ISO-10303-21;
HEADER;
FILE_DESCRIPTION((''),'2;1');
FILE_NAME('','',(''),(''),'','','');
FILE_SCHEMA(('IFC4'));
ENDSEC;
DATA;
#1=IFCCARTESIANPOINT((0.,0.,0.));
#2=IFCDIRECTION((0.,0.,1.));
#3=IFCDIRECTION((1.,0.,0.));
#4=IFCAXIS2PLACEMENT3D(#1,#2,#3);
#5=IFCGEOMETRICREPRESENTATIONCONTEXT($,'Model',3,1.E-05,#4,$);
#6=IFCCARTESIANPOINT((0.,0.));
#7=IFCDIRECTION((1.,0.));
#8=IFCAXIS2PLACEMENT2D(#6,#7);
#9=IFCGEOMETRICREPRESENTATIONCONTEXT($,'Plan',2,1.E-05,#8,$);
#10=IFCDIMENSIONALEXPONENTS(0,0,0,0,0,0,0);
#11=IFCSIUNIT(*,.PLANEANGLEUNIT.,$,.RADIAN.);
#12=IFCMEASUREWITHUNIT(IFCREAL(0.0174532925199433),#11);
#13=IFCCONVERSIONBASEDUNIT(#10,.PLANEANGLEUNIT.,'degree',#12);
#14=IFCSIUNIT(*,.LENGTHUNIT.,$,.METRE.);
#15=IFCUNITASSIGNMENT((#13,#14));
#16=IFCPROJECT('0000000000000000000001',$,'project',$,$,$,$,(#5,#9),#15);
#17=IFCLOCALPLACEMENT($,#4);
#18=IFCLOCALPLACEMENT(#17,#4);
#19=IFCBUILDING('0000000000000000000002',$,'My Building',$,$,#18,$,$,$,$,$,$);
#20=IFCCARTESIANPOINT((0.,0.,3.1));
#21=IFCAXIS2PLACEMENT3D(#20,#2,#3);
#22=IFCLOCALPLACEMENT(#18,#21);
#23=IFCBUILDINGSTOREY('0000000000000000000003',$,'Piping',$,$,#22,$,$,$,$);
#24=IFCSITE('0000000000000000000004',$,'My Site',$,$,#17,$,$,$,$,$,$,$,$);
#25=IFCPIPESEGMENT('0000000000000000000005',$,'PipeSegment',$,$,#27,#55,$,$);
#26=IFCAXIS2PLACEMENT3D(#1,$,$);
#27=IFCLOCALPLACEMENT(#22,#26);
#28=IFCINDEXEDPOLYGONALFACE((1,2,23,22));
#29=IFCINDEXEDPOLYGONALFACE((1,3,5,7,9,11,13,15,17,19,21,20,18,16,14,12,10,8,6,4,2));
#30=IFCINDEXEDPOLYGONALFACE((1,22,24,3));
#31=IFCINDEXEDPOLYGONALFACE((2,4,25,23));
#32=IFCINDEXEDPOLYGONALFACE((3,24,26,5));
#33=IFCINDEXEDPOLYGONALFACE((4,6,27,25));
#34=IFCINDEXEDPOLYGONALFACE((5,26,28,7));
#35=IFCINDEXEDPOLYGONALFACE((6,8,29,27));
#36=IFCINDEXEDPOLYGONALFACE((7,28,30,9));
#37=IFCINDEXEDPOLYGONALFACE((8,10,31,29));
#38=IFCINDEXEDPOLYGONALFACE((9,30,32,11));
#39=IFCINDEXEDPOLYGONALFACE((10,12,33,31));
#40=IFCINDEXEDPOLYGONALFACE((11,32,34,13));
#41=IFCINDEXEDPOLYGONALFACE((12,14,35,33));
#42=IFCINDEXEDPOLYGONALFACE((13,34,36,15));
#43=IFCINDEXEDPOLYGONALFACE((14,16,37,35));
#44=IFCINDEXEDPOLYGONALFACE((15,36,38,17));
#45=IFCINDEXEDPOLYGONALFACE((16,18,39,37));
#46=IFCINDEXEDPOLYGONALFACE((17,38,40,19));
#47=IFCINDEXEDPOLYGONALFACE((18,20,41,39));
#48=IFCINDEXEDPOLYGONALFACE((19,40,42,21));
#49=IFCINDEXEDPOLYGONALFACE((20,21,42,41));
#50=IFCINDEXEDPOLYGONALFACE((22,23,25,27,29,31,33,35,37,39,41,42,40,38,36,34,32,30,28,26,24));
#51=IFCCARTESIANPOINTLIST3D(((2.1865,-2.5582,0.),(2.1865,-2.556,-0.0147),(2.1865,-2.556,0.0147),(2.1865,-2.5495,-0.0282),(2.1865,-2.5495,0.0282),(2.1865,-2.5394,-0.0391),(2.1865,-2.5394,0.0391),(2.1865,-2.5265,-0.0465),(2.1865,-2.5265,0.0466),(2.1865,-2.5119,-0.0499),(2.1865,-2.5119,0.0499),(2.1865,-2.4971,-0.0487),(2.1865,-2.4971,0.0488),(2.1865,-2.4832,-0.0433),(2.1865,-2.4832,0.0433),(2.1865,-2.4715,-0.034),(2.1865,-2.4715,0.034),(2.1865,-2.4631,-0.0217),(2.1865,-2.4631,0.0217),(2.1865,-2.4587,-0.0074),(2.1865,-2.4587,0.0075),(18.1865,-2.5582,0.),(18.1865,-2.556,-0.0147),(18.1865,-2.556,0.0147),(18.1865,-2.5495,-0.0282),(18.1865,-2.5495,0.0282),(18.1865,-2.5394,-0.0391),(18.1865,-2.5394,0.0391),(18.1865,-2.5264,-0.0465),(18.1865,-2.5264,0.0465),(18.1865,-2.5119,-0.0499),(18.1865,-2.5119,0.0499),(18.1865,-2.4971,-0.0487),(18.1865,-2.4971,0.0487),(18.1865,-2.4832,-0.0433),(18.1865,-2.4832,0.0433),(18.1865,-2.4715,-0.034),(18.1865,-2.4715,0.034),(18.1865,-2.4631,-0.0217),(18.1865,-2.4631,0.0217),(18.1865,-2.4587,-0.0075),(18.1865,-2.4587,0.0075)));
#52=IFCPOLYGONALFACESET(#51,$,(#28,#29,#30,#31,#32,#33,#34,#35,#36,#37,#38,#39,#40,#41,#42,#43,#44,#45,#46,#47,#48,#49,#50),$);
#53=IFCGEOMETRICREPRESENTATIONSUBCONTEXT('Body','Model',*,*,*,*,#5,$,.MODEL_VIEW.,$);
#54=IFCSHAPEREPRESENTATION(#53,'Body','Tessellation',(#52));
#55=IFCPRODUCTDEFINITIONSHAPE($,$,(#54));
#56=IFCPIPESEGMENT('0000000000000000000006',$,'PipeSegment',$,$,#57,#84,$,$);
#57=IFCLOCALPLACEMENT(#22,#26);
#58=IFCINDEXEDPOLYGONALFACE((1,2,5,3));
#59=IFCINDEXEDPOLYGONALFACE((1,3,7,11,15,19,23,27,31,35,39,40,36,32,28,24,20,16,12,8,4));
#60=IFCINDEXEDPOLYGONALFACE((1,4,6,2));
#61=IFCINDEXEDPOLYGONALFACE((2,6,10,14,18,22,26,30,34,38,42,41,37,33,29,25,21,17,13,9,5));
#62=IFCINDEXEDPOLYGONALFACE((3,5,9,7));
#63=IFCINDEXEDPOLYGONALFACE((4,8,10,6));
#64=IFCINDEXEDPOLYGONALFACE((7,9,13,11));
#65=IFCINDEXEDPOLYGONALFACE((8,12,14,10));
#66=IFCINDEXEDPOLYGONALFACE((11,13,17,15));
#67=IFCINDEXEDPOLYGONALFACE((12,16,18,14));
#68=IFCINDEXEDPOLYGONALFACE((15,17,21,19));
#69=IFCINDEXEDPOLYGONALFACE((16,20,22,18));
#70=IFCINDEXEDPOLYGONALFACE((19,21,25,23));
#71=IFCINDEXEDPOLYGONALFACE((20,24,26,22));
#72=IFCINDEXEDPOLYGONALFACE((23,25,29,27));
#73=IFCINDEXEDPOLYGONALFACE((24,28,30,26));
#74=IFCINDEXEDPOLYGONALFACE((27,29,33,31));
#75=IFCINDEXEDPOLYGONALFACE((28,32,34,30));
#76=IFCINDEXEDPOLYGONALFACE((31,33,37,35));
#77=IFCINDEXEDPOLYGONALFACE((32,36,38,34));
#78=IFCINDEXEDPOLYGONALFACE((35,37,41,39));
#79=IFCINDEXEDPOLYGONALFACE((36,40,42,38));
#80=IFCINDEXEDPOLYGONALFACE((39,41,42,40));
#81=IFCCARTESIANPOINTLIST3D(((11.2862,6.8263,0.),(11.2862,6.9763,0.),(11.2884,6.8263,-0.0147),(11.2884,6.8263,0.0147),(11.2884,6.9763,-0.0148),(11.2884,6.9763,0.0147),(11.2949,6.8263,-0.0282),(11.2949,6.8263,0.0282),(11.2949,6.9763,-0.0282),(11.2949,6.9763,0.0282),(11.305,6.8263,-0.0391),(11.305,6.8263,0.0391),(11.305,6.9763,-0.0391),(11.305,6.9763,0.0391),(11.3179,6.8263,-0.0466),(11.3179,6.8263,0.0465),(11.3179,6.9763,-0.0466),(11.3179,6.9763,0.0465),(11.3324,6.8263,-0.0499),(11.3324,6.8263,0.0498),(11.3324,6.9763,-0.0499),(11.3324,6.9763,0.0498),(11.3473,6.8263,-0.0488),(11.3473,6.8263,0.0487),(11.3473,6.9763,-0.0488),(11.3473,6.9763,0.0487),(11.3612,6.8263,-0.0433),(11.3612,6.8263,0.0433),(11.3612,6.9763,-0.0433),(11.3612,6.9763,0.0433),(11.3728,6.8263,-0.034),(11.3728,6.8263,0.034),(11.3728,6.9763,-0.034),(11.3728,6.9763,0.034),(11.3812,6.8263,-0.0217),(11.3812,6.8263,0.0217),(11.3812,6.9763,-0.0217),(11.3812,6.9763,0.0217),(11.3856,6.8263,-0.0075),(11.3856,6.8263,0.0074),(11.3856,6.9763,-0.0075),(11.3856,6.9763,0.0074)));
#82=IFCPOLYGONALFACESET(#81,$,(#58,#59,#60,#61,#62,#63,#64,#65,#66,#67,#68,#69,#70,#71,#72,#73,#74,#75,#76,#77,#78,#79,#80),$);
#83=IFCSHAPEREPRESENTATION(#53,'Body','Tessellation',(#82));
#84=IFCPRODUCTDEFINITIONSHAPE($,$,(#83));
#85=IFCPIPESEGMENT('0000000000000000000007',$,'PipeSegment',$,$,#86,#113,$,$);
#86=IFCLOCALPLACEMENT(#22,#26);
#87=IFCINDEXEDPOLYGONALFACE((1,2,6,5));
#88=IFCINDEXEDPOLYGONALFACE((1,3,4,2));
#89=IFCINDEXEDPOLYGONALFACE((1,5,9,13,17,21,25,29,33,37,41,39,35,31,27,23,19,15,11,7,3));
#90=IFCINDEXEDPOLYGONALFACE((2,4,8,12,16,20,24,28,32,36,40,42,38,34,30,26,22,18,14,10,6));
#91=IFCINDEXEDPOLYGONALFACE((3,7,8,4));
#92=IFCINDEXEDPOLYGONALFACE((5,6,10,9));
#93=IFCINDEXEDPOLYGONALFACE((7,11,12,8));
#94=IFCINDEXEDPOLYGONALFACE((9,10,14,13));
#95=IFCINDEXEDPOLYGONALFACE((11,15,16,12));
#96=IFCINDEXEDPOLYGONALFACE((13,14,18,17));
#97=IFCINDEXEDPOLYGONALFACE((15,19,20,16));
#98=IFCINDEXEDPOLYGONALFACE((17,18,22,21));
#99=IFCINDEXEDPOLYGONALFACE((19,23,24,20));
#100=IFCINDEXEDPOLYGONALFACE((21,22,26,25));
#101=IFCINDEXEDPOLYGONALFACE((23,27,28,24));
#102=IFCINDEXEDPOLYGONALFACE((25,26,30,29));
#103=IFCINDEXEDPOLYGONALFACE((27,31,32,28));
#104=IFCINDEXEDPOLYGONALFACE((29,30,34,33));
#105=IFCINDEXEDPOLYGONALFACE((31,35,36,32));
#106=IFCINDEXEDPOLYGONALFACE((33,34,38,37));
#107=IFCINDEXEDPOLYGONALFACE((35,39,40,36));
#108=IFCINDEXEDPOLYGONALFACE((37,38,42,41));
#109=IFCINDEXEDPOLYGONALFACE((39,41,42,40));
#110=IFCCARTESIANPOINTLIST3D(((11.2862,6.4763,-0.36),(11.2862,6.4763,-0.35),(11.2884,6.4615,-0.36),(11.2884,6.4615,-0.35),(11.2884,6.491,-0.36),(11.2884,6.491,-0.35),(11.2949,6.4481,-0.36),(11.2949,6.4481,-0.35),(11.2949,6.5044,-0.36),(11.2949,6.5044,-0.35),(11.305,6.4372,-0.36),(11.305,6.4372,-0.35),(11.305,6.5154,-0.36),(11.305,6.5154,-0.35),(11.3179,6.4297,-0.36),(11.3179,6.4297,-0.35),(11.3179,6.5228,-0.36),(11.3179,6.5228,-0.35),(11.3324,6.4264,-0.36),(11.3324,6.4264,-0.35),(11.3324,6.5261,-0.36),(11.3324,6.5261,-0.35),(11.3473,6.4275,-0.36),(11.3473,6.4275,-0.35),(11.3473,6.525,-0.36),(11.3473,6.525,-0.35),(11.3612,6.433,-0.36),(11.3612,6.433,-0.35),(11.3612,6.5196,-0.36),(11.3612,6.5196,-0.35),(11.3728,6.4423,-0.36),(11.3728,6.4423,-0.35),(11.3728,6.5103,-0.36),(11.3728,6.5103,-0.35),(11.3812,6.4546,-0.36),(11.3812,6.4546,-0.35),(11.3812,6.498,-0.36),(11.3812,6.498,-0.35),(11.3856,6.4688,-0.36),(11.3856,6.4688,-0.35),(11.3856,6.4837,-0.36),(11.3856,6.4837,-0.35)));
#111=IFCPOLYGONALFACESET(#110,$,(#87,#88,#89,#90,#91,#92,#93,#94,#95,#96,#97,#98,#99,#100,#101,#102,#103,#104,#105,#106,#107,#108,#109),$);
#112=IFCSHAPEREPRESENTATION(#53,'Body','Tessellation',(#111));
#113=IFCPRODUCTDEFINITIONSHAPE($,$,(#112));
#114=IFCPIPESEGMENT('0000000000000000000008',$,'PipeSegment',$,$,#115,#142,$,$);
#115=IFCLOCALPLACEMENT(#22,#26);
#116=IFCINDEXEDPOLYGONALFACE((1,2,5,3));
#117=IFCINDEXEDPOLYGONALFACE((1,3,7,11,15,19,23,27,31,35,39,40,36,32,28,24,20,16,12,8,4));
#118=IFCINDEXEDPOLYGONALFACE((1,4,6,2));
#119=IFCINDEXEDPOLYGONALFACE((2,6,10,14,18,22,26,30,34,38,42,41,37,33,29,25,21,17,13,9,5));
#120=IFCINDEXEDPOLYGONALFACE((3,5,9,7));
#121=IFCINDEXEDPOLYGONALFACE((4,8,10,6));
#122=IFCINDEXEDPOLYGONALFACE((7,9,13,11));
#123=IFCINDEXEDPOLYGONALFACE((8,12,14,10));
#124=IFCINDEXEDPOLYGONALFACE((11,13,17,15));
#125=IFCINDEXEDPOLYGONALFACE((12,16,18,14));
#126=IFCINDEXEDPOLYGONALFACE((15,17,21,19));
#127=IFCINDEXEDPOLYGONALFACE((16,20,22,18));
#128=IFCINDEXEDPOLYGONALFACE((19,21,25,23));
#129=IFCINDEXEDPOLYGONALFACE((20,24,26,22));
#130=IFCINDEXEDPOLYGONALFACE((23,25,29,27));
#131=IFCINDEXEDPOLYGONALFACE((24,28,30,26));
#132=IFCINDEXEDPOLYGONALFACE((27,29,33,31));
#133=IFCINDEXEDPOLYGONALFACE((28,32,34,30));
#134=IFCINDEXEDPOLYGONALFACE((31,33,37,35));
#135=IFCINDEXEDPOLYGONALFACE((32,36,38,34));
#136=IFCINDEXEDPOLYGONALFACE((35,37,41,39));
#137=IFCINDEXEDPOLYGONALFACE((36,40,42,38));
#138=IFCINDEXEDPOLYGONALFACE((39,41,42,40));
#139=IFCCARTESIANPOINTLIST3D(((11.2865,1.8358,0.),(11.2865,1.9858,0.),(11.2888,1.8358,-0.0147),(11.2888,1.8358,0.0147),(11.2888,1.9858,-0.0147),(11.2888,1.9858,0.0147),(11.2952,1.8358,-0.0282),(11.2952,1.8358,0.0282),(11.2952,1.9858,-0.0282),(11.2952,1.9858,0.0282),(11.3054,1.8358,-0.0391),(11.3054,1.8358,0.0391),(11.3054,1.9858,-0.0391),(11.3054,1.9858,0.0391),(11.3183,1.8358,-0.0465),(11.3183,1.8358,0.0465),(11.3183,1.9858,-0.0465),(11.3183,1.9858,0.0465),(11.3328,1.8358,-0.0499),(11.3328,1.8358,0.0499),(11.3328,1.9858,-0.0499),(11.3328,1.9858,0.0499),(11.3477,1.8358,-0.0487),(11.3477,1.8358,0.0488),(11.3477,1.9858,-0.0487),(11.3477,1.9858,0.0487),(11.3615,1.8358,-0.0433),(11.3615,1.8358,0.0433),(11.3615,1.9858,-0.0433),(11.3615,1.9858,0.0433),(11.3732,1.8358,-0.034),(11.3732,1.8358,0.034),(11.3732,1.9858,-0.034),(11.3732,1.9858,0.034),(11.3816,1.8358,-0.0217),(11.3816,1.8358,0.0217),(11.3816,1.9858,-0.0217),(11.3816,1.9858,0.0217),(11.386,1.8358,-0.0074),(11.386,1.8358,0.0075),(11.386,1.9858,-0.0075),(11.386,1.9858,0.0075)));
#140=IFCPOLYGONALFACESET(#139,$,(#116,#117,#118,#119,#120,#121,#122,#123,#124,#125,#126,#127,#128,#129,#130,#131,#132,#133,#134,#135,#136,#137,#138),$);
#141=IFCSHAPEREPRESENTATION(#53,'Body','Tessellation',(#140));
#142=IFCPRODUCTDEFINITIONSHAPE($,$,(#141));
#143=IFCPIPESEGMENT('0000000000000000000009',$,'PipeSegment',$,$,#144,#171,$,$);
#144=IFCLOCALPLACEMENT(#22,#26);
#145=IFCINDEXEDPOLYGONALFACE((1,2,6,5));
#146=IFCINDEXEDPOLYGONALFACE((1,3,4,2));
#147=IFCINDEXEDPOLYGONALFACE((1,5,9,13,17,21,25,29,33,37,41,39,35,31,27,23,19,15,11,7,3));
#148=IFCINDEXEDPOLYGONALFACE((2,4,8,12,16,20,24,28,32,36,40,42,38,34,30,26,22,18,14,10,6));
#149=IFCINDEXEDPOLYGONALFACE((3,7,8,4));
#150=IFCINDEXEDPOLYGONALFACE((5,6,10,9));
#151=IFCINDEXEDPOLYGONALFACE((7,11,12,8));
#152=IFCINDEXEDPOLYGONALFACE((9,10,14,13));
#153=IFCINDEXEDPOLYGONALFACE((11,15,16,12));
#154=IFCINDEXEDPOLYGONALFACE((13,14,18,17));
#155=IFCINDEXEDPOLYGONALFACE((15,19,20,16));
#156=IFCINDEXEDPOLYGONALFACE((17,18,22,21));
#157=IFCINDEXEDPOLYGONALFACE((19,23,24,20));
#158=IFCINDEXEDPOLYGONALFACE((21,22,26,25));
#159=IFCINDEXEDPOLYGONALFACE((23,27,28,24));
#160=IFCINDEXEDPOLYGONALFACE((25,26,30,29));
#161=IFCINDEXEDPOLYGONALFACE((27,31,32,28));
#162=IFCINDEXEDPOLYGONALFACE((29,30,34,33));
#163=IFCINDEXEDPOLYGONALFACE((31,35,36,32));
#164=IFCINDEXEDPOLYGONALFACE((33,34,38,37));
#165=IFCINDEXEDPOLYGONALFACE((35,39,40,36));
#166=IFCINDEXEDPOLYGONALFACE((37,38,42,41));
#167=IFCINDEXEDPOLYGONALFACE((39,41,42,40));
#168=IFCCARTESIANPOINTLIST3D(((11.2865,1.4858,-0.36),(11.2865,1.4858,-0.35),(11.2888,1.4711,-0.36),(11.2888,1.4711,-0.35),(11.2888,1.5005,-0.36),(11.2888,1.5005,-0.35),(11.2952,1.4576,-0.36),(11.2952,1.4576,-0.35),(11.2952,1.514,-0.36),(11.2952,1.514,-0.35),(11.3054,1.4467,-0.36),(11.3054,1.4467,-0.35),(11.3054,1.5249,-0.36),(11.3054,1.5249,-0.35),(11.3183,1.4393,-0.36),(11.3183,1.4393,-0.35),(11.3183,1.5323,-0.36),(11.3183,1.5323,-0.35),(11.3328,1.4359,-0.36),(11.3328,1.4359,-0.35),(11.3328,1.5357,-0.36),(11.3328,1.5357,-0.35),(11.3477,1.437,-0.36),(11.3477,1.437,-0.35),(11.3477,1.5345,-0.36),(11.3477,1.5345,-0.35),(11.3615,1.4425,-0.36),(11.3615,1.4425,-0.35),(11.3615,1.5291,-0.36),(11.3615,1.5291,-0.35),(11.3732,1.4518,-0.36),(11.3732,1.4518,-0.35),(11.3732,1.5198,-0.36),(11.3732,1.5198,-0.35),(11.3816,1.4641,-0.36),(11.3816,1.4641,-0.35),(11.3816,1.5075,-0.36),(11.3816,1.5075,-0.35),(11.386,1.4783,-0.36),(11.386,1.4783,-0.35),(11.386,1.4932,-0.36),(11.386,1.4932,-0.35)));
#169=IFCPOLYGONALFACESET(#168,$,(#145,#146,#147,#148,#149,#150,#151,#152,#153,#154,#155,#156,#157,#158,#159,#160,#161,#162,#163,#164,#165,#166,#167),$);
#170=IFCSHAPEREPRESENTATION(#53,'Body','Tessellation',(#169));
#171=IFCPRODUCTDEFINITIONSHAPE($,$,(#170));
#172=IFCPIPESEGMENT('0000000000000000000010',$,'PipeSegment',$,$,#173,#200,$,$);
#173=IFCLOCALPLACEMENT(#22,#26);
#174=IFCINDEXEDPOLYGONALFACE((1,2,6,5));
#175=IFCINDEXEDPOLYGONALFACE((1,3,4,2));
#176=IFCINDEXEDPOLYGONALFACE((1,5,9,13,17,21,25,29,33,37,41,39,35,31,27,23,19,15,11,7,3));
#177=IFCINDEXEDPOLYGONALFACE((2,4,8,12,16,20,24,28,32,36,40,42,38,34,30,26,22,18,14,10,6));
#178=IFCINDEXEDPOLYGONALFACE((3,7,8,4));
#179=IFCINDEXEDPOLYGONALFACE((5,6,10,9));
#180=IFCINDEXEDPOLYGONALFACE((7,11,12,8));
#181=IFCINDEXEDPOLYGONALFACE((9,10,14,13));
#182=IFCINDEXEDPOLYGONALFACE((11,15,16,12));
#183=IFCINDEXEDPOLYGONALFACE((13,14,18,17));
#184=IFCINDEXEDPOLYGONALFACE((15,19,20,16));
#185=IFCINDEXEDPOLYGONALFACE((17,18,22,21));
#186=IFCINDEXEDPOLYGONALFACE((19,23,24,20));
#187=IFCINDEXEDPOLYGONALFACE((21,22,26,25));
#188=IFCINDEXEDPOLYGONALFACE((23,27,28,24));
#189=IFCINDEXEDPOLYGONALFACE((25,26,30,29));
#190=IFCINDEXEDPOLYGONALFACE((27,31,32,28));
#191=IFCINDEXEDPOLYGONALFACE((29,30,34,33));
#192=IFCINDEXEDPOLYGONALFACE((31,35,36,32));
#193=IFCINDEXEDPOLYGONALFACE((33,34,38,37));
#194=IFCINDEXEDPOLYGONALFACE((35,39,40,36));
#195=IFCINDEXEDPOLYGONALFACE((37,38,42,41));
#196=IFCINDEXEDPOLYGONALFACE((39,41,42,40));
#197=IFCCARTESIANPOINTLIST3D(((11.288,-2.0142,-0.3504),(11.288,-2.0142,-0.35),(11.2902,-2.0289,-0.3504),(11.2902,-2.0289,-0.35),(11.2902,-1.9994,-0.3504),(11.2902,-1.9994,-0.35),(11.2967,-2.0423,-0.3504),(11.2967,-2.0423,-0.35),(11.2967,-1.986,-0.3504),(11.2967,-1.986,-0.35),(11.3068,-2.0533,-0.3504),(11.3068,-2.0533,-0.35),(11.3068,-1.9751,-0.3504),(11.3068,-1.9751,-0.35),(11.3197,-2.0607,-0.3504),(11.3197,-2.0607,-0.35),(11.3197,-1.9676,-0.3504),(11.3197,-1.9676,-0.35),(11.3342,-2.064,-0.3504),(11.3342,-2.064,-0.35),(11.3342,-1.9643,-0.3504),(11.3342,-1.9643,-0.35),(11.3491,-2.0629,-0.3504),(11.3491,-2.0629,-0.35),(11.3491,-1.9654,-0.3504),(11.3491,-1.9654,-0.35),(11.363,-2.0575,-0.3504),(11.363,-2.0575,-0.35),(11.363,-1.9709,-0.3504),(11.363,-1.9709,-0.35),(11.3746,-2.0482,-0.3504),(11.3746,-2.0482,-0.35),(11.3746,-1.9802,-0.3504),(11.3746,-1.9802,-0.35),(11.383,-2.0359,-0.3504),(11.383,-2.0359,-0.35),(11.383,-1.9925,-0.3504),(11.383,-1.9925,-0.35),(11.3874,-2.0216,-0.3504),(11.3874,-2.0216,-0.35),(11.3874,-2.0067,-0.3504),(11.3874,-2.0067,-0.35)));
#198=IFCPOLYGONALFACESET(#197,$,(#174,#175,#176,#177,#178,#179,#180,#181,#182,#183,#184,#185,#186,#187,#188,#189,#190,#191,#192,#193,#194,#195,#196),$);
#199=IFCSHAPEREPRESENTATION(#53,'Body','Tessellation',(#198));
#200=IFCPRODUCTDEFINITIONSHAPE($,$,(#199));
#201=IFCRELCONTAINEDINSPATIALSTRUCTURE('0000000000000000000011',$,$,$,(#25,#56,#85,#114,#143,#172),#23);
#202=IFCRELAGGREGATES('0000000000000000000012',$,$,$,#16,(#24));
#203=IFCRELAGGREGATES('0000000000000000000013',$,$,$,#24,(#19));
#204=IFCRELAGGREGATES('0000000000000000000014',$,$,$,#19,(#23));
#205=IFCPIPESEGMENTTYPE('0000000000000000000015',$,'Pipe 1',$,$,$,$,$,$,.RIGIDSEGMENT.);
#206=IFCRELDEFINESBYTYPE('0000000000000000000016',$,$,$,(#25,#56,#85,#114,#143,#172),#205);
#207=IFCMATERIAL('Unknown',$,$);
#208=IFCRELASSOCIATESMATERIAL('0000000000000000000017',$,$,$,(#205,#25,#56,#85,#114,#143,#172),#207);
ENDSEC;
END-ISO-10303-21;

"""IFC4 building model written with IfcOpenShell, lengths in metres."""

from ifc_helpers import new_model, entity, si_unit, converted_unit, frame, origin_with_axes, origin_2d_with_axis, place, context, subcontext, project, spatial, circle, extrude, material, material_profile, profile_set, profile_usage, type_object, element, save


model = new_model("IFC4")

# Units and contexts
model_context = context("Model", 3, precision=1e-05, world=origin_with_axes())
plan_context = context("Plan", 2, precision=1e-05, world=origin_2d_with_axis())
body_context = subcontext(model_context, "Body", "Model", "MODEL_VIEW")
ifc_project = project(units=[converted_unit("PLANEANGLEUNIT", "degree", entity("IfcReal", 0.0174532925199433), si_unit("PLANEANGLEUNIT", "RADIAN"), dimensions=[0, 0, 0, 0, 0, 0, 0]), si_unit("LENGTHUNIT", "METRE")], contexts=[model_context, plan_context])

# Site, building, storey
site_placement = place(None, origin_with_axes())
site = spatial("IfcSite", under=ifc_project, at=site_placement, Name="My Site")
building_placement = place(site_placement, origin_with_axes())
building = spatial("IfcBuilding", under=site, at=building_placement, Name="My Building")
storey_placement = place(building_placement, frame((0.0, 0.0, 3.1), z_axis=(0.0, 0.0, 1.0), x_axis=(1.0, 0.0, 0.0)))
storey = spatial("IfcBuildingStorey", under=building, at=storey_placement, Name="Piping")

# Pipe segments
ifc_material = material(Name="Unknown")
ifc_material_profile = material_profile(ifc_material, circle(Radius=0.05))
ifc_profile_set = profile_set([ifc_material_profile])
ifc_profile_usage_1 = profile_usage(ifc_profile_set, cardinal=5)
pipe_segment_type = type_object("IfcPipeSegmentType", Name="Pipe 1", PredefinedType="RIGIDSEGMENT", material=ifc_profile_set)
pipe_segment_1_placement = place(storey_placement, frame((18.1865, -2.5082, 0.0), z_axis=(-1.0, -0.000001, 0.0), x_axis=(0.000001, -1.0, 0.0)))
element("IfcPipeSegment", 1, at=pipe_segment_1_placement, inside=storey, type_object=pipe_segment_type, material=ifc_profile_usage_1, Name="PipeSegment", context=body_context, shape_type="SweptSolid", body=[
    extrude(circle(Radius=0.05), origin_with_axes(), (0.0, 0.0, 1.0), 16.0),
])
ifc_profile_usage_2 = profile_usage(ifc_profile_set, cardinal=5)
pipe_segment_2_placement = place(storey_placement, frame((11.3362, 6.8263, 0.0), z_axis=(0.0, 1.0, -0.000022), x_axis=(-1.0, 0.0, 0.0)))
element("IfcPipeSegment", 2, at=pipe_segment_2_placement, inside=storey, type_object=pipe_segment_type, material=ifc_profile_usage_2, Name="PipeSegment", context=body_context, shape_type="SweptSolid", body=[
    extrude(circle(Radius=0.05), origin_with_axes(), (0.0, 0.0, 1.0), 0.15),
])
ifc_profile_usage_3 = profile_usage(ifc_profile_set, cardinal=5)
pipe_segment_3_placement = place(storey_placement, frame((11.3362, 6.4763, -0.35), z_axis=(0.0, 0.0, -1.0), x_axis=(-1.0, 0.0, 0.0)))
element("IfcPipeSegment", 3, at=pipe_segment_3_placement, inside=storey, type_object=pipe_segment_type, material=ifc_profile_usage_3, Name="PipeSegment", context=body_context, shape_type="SweptSolid", body=[
    extrude(circle(Radius=0.05), origin_with_axes(), (0.0, 0.0, 1.0), 0.01),
])
ifc_profile_usage_4 = profile_usage(ifc_profile_set, cardinal=5)
pipe_segment_4_placement = place(storey_placement, frame((11.3365, 1.8358, 0.0), z_axis=(0.0, 1.0, -0.000022), x_axis=(-1.0, 0.0, 0.0)))
element("IfcPipeSegment", 4, at=pipe_segment_4_placement, inside=storey, type_object=pipe_segment_type, material=ifc_profile_usage_4, Name="PipeSegment", context=body_context, shape_type="SweptSolid", body=[
    extrude(circle(Radius=0.05), origin_with_axes(), (0.0, 0.0, 1.0), 0.15),
])
ifc_profile_usage_5 = profile_usage(ifc_profile_set, cardinal=5)
pipe_segment_5_placement = place(storey_placement, frame((11.3365, 1.4858, -0.35), z_axis=(0.0, 0.0, -1.0), x_axis=(-1.0, 0.0, 0.0)))
element("IfcPipeSegment", 5, at=pipe_segment_5_placement, inside=storey, type_object=pipe_segment_type, material=ifc_profile_usage_5, Name="PipeSegment", context=body_context, shape_type="SweptSolid", body=[
    extrude(circle(Radius=0.05), origin_with_axes(), (0.0, 0.0, 1.0), 0.01),
])
ifc_profile_usage_6 = profile_usage(ifc_profile_set, cardinal=5)
pipe_segment_6_placement = place(storey_placement, frame((11.338, -2.0142, -0.35), z_axis=(0.0, 0.0, -1.0), x_axis=(-1.0, 0.0, 0.0)))
element("IfcPipeSegment", 6, at=pipe_segment_6_placement, inside=storey, type_object=pipe_segment_type, material=ifc_profile_usage_6, Name="PipeSegment", context=body_context, shape_type="SweptSolid", body=[
    extrude(circle(Radius=0.05), origin_with_axes(), (0.0, 0.0, 1.0), 0.0004),
])

save(model, "model.ifc")
